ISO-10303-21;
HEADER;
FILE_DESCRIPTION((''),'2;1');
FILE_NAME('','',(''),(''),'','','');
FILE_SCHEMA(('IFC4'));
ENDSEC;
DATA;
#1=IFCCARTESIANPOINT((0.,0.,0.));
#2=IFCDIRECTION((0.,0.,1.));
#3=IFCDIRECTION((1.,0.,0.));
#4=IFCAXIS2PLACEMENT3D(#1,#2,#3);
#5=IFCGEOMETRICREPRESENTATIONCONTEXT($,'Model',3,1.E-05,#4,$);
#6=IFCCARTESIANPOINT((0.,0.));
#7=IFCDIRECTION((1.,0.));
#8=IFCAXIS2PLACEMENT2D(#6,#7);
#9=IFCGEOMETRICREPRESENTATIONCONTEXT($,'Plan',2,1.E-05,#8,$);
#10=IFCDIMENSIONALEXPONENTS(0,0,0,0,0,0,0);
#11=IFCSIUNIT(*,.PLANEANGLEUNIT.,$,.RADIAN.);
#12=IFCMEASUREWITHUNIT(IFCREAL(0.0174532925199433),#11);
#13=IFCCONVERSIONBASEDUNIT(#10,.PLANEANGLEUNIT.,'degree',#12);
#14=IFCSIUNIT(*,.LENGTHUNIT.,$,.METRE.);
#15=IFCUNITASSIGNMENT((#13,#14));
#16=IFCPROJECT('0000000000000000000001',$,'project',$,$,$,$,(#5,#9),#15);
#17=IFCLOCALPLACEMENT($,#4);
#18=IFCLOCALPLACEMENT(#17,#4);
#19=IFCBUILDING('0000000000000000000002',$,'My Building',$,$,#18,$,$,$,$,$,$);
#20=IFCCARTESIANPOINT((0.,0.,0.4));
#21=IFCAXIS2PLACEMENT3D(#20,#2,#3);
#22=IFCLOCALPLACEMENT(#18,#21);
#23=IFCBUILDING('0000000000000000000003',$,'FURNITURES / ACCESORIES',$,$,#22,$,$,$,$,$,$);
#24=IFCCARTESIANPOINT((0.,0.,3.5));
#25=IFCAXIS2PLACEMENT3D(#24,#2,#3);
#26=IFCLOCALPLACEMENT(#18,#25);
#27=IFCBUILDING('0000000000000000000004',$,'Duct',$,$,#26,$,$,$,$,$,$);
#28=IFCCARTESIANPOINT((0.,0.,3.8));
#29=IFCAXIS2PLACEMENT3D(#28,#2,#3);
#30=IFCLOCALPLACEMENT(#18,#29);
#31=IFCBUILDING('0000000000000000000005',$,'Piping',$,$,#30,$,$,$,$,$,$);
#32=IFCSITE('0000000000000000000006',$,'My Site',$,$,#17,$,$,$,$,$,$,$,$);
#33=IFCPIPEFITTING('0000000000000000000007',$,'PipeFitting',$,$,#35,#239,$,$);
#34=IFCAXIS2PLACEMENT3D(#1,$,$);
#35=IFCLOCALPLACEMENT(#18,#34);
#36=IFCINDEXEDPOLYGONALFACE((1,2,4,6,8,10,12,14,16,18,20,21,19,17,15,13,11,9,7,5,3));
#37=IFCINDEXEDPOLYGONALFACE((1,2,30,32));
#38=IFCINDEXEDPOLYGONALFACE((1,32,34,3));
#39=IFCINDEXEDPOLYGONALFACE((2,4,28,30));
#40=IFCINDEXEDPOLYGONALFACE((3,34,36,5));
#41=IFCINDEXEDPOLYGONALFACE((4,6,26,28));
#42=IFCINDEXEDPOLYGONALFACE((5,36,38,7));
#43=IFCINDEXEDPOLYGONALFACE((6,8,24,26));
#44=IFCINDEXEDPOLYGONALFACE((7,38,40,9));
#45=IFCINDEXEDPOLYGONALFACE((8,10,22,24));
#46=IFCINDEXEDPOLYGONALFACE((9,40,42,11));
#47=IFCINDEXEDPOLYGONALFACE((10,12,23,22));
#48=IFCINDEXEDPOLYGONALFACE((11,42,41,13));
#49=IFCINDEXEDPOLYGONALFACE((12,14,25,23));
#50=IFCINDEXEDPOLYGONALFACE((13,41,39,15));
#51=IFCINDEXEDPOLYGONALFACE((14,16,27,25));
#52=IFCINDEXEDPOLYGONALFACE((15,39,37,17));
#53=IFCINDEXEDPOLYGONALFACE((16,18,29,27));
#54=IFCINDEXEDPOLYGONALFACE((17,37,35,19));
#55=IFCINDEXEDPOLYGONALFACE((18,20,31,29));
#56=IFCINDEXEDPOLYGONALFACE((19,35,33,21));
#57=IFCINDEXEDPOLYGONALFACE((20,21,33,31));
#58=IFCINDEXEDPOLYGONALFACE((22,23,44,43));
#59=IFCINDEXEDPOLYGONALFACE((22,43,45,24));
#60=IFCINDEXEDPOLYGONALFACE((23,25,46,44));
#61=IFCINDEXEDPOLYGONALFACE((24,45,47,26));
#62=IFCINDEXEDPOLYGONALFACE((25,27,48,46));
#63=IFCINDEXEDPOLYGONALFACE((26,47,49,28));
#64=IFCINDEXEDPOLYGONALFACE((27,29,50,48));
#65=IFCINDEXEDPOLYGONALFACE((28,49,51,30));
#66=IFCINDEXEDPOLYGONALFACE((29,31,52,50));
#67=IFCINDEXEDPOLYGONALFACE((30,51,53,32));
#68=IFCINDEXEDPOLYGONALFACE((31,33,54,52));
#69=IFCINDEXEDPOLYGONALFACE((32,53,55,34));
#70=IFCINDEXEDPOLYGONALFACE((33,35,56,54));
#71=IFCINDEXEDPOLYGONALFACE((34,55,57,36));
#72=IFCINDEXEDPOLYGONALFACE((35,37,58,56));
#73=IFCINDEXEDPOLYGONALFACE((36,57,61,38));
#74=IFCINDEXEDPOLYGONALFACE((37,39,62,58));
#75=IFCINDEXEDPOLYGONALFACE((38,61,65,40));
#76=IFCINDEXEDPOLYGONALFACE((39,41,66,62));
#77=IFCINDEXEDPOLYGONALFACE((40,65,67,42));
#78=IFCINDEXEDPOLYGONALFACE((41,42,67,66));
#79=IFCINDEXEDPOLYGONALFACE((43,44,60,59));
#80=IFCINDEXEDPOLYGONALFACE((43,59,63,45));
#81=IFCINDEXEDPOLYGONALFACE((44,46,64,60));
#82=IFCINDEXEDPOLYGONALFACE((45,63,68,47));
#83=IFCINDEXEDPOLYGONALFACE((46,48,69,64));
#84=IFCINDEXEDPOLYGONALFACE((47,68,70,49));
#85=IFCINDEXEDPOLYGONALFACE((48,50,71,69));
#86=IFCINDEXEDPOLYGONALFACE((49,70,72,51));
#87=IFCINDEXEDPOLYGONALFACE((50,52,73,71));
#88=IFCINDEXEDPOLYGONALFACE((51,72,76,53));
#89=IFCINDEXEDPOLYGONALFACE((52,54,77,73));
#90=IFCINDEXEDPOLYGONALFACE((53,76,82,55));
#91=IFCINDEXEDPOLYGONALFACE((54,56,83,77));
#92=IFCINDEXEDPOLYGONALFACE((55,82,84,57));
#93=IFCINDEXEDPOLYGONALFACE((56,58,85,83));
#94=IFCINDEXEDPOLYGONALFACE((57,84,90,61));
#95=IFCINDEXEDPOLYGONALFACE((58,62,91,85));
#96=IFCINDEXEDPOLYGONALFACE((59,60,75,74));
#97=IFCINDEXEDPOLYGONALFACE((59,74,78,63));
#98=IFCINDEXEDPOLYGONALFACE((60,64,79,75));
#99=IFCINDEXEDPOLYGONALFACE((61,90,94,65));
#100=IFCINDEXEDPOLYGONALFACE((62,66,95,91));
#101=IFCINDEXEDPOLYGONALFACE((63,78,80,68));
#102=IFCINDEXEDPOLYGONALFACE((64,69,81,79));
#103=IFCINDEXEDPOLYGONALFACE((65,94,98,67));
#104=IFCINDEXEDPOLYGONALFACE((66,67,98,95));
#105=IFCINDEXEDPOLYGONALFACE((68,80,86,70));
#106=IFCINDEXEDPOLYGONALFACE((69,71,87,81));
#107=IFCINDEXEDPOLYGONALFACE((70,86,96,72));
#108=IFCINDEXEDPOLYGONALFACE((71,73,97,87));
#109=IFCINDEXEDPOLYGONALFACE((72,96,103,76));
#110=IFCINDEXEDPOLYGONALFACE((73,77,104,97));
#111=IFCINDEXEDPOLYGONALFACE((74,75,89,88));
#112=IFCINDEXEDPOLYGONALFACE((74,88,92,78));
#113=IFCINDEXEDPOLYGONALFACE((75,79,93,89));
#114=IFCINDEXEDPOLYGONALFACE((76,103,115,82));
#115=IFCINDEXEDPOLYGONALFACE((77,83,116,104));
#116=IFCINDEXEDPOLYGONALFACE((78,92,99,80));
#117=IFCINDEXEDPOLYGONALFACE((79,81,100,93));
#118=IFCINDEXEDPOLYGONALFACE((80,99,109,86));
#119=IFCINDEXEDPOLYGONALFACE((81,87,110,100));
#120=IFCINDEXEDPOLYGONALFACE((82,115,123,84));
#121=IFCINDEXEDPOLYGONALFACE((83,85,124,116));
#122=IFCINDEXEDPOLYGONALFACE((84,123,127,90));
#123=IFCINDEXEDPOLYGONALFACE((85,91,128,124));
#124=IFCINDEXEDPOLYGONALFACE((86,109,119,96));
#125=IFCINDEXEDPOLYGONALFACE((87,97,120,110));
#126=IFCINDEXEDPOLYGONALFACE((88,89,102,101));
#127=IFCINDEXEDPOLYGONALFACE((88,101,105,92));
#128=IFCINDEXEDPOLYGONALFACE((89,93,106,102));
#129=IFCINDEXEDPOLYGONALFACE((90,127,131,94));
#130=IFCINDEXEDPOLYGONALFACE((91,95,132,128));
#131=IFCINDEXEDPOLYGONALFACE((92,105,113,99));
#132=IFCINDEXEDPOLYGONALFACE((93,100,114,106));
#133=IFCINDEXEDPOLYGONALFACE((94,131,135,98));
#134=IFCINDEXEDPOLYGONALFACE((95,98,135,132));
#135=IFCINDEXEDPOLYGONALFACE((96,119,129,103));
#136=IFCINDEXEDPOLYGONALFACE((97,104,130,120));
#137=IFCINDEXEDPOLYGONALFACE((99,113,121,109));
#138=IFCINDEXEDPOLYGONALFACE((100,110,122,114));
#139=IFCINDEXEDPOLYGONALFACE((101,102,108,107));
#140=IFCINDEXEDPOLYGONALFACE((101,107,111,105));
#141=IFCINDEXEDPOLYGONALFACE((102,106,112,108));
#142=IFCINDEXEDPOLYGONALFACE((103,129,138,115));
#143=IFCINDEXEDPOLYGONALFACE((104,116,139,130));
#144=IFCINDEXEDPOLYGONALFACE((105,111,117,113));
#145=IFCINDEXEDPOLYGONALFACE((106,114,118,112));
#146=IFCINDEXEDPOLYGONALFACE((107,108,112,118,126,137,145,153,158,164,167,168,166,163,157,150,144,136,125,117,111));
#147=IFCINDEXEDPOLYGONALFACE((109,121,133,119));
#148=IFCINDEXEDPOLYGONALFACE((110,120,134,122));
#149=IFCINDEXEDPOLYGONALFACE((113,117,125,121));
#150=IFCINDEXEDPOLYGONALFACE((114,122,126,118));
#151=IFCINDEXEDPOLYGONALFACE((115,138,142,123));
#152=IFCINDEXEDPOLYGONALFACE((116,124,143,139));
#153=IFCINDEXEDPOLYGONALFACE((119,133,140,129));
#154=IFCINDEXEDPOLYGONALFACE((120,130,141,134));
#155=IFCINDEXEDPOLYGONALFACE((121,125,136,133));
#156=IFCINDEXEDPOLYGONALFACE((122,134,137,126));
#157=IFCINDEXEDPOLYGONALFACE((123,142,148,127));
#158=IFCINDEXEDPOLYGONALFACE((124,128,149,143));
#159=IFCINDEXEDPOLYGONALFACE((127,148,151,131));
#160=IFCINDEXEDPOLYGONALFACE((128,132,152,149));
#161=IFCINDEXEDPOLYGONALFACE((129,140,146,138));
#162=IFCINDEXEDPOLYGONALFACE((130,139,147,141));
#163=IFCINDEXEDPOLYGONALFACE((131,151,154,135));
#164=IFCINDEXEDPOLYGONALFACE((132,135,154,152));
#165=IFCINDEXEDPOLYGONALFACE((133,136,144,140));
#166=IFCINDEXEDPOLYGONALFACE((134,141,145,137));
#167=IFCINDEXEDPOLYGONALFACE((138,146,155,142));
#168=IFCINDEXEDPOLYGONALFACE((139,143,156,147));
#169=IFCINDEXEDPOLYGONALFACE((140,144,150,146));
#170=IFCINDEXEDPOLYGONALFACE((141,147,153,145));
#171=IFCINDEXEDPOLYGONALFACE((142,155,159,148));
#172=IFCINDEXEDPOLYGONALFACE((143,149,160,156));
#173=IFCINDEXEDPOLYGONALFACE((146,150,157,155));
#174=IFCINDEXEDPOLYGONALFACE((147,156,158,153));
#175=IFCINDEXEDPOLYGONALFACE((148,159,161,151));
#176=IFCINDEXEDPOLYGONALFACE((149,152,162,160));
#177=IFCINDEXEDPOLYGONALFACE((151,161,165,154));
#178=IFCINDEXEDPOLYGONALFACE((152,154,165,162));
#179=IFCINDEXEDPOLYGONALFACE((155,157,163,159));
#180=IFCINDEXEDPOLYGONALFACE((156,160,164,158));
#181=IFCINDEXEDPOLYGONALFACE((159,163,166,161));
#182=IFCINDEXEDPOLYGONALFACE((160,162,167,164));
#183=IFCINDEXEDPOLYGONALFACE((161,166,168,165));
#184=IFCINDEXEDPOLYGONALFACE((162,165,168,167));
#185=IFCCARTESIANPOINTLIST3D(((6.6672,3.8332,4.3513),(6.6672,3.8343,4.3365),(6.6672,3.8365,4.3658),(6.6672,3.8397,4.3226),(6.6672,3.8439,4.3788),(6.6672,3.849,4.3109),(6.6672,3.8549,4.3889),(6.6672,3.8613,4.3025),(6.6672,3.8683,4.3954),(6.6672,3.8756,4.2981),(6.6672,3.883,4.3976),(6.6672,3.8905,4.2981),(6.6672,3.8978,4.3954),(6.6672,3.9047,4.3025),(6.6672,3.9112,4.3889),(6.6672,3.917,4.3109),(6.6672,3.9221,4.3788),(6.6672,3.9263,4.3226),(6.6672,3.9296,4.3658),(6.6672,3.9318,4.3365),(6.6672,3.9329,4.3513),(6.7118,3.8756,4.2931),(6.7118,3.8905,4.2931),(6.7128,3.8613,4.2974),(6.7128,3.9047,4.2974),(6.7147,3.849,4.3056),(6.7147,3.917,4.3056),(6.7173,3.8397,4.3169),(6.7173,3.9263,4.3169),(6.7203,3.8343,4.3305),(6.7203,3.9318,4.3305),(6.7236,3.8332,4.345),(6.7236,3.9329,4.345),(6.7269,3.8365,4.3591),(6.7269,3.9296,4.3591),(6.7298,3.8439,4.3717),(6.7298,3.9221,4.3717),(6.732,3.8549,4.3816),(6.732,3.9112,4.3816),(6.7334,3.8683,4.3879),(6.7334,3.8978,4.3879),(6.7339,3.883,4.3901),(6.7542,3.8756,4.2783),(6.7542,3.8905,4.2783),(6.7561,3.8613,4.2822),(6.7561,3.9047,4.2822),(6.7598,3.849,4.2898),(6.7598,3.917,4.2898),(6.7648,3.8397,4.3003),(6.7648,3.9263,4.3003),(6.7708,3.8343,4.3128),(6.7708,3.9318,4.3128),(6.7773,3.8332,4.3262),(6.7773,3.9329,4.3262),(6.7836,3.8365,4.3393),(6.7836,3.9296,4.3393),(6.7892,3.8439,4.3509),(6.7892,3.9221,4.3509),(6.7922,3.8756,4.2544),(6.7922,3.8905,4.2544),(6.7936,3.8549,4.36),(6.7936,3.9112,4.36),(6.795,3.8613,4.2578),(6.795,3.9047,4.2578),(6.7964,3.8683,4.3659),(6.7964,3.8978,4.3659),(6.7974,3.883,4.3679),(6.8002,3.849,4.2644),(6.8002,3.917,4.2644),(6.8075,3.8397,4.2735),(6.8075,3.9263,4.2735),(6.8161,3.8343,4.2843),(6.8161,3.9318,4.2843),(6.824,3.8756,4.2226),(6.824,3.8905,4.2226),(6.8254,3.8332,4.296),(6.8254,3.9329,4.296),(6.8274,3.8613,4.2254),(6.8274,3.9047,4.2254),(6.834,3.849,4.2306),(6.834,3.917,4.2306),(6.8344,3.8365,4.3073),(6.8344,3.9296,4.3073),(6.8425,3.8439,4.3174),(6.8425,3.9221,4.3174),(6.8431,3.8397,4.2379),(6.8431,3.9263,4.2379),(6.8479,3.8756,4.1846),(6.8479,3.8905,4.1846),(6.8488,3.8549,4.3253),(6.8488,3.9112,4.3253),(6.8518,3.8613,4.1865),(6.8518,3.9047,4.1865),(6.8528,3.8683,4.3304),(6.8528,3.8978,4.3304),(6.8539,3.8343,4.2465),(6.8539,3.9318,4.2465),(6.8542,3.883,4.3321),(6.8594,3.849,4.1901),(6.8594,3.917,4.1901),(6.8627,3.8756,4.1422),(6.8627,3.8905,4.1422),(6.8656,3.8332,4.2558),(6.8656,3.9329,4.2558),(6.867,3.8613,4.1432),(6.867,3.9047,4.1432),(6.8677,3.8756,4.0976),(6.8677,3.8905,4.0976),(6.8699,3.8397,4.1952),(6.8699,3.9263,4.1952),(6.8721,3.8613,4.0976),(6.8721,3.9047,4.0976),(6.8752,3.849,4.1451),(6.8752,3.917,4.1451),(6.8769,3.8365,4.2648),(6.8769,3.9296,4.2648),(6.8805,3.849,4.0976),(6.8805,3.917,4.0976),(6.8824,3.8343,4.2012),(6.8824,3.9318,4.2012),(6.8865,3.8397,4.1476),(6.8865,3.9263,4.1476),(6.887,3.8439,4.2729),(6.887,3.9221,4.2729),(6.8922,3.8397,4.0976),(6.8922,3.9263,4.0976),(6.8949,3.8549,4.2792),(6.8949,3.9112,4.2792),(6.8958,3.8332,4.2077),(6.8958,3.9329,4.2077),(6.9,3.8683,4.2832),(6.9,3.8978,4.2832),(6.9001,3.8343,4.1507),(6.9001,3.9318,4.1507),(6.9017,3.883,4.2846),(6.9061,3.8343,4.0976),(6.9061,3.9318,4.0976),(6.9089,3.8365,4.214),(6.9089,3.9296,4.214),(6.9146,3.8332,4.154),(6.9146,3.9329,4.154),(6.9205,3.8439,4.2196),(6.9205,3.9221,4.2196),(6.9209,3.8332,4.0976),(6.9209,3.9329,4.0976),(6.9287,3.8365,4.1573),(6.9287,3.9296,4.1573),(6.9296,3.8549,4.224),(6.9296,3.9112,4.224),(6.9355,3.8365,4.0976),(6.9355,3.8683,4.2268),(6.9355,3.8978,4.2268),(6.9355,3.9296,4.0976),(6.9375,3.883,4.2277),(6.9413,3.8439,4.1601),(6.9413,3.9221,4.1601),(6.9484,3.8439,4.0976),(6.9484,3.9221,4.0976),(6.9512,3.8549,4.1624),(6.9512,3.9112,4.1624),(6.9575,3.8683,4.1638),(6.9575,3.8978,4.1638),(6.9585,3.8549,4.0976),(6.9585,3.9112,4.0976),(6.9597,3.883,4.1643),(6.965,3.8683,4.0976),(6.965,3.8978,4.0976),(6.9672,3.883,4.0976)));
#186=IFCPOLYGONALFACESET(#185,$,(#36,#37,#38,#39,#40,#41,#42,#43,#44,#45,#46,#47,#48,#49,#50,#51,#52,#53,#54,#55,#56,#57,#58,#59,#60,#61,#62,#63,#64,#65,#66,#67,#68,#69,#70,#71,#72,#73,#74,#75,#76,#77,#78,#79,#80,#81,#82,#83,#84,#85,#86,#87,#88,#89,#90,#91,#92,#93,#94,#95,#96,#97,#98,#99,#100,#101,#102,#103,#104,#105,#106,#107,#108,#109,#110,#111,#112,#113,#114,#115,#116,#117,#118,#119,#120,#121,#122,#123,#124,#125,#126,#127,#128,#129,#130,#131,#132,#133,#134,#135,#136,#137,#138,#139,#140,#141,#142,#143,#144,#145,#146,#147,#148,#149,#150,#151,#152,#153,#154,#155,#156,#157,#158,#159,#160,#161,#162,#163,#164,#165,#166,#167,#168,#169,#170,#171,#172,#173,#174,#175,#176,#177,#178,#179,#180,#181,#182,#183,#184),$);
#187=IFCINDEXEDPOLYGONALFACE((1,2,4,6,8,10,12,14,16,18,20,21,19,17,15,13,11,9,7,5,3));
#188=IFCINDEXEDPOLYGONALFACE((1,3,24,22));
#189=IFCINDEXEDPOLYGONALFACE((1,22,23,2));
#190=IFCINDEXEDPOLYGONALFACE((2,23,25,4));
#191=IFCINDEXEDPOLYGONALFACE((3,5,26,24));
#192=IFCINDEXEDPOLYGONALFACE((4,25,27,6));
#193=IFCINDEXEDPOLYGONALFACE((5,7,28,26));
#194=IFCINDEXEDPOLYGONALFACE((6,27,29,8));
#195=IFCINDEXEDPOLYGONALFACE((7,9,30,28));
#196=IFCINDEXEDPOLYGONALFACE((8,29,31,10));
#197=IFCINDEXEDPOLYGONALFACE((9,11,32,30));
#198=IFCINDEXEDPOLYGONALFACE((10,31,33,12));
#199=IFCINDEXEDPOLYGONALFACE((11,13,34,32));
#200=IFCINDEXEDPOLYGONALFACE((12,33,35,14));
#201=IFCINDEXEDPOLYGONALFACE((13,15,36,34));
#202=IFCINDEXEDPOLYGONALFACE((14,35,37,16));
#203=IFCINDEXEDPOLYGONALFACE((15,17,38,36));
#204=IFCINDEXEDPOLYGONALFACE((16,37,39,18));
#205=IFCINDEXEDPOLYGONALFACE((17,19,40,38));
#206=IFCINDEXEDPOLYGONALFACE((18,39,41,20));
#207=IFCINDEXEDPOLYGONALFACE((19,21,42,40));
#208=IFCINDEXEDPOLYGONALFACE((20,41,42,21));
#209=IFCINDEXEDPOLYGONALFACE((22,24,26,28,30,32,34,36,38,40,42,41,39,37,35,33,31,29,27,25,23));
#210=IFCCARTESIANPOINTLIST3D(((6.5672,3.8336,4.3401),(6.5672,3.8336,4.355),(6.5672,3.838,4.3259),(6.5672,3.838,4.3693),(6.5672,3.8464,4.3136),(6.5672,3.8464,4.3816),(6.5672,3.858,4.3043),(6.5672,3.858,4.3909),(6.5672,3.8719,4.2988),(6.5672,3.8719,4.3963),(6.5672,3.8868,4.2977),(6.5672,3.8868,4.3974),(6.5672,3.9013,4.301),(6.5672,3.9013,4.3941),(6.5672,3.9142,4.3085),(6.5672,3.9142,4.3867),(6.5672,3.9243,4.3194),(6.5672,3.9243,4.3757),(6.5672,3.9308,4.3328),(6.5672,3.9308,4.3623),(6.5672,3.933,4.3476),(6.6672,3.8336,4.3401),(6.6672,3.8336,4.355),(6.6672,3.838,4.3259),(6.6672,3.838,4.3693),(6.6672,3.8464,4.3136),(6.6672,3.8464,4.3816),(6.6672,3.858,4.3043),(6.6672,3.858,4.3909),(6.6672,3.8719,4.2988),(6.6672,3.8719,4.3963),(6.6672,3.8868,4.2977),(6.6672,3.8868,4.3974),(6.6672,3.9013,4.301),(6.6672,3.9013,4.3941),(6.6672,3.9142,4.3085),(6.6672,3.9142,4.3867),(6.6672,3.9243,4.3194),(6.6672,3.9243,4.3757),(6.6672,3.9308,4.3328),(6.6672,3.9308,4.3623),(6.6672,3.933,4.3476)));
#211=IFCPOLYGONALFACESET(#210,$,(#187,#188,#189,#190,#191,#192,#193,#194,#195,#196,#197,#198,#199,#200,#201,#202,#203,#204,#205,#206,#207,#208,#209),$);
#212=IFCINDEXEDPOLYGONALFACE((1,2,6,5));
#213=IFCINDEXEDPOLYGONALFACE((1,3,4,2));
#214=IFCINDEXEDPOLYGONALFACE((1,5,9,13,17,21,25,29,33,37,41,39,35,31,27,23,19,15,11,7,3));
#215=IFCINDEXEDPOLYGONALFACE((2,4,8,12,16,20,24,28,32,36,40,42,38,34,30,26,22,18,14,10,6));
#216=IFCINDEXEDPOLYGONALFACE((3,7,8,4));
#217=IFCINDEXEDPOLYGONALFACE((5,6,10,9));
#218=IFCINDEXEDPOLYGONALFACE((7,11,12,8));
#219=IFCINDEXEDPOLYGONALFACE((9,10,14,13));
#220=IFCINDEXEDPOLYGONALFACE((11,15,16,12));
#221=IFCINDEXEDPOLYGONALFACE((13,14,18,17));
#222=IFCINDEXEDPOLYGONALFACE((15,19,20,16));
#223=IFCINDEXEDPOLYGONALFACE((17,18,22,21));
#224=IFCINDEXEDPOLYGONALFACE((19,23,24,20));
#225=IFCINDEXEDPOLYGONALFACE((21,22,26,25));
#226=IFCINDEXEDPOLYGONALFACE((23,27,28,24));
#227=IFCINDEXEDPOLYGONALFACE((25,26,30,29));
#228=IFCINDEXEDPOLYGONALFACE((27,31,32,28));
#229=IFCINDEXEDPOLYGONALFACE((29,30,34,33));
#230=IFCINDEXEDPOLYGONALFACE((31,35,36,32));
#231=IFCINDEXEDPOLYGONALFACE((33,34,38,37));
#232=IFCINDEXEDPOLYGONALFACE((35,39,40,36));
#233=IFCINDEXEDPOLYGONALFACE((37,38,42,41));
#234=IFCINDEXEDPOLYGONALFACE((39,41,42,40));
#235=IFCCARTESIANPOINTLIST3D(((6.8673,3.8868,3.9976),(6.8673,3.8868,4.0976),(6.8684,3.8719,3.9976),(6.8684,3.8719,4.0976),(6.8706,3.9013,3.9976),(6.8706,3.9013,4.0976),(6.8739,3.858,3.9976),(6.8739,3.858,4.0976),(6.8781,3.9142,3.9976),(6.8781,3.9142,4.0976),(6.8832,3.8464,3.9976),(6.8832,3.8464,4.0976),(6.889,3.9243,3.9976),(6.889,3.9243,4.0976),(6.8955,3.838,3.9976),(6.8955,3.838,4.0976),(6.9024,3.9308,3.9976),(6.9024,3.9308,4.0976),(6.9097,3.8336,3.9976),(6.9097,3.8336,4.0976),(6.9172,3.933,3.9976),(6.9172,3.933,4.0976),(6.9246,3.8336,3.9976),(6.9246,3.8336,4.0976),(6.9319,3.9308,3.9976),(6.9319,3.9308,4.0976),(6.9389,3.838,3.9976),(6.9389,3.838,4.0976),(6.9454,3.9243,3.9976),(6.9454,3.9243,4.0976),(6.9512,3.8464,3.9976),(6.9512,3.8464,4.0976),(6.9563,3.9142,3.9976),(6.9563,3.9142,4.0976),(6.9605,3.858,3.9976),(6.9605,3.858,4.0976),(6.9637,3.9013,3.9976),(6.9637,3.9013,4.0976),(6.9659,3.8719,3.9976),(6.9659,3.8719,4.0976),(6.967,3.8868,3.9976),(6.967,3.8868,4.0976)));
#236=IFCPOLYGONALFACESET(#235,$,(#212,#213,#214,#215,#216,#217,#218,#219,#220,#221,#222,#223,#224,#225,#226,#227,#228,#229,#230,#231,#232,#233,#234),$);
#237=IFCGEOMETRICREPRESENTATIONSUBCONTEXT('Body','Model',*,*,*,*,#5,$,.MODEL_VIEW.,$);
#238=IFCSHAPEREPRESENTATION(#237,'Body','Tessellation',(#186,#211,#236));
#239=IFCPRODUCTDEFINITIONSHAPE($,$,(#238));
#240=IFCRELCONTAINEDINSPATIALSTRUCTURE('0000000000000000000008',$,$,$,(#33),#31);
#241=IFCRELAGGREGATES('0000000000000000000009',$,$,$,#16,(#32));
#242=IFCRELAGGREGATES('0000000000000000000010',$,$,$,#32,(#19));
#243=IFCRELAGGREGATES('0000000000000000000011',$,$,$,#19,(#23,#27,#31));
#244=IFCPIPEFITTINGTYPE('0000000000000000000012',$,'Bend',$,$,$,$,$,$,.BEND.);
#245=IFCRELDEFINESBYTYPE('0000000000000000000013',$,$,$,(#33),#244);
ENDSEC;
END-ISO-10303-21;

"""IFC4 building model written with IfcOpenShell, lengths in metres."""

from ifc_helpers import new_model, entity, si_unit, converted_unit, frame, origin_with_axes, origin_2d_with_axis, place, context, subcontext, project, spatial, circle, extrude, source, transform, mapped, type_object, type_shapes, element, save


model = new_model("IFC4")

# Units and contexts
model_context = context("Model", 3, precision=1e-05, world=origin_with_axes())
plan_context = context("Plan", 2, precision=1e-05, world=origin_2d_with_axis())
body_context = subcontext(model_context, "Body", "Model", "MODEL_VIEW")
ifc_project = project(units=[converted_unit("PLANEANGLEUNIT", "degree", entity("IfcReal", 0.0174532925199433), si_unit("PLANEANGLEUNIT", "RADIAN"), dimensions=[0, 0, 0, 0, 0, 0, 0]), si_unit("LENGTHUNIT", "METRE")], contexts=[model_context, plan_context])

# Site, building
site_placement = place(None, origin_with_axes())
site = spatial("IfcSite", under=ifc_project, at=site_placement, Name="My Site")
building_1_placement = place(site_placement, origin_with_axes())
building_1 = spatial("IfcBuilding", under=site, at=building_1_placement, Name="My Building")

# Shared definitions
building_2_placement = place(building_1_placement, frame((0.0, 0.0, 0.4), z_axis=(0.0, 0.0, 1.0), x_axis=(1.0, 0.0, 0.0)))
building_2 = spatial("IfcBuilding", under=building_1, at=building_2_placement, Name="FURNITURES / ACCESORIES")

# Shared definitions
building_3_placement = place(building_1_placement, frame((0.0, 0.0, 3.5), z_axis=(0.0, 0.0, 1.0), x_axis=(1.0, 0.0, 0.0)))
building_3 = spatial("IfcBuilding", under=building_1, at=building_3_placement, Name="Duct")

# Shared definitions
building_4_placement = place(building_1_placement, frame((0.0, 0.0, 3.8), z_axis=(0.0, 0.0, 1.0), x_axis=(1.0, 0.0, 0.0)))
building_4 = spatial("IfcBuilding", under=building_1, at=building_4_placement, Name="Piping")

# Pipe fitting
pipe_fitting_type = type_object("IfcPipeFittingType", Name="Bend", PredefinedType="BEND")
shared_shape = source(origin_with_axes(), body_context, "Body", "SolidModel", [
    entity("IfcSweptDiskSolid", entity("IfcIndexedPolyCurve", entity("IfcCartesianPointList3D", [[0.0, 0.0, 0.1], [0.0, -0.0732, 0.2768], [0.0, -0.25, 0.35]]), [entity("IfcArcIndex", [1, 2, 3])]), 0.05),
    extrude(circle(Radius=0.05), origin_with_axes(), (0.0, 0.0, 1.0), 0.1),
    extrude(circle(Radius=0.05), frame((0.0, -0.25, 0.35), z_axis=(0.0, -1.0, -0.000001), x_axis=(1.0, 0.0, 0.0)), (0.0, 0.0, 1.0), 0.1),
])
type_shapes(pipe_fitting_type, [shared_shape])
for number, where, z_axis, x_axis, name in (
    (1, (6.5672, 3.883, 0.5476), (1.0, -0.000001, 0.000001), (0.000001, 1.0, 0.0), "PipeFitting"),
):
    element("IfcPipeFitting", number, at=place(building_4_placement, frame(where, z_axis=z_axis, x_axis=x_axis)), inside=building_4, type_object=pipe_fitting_type, Name=name, context=body_context, shape_type="MappedRepresentation", body=[
        mapped(shared_shape, transform((0.0, 0.0, 0.0), x_axis=(1.0, 0.0, 0.0), y_axis=(0.0, 1.0, 0.0), z_axis=(0.0, 0.0, 1.0), scale=1.0)),
    ])

save(model, "model.ifc")
